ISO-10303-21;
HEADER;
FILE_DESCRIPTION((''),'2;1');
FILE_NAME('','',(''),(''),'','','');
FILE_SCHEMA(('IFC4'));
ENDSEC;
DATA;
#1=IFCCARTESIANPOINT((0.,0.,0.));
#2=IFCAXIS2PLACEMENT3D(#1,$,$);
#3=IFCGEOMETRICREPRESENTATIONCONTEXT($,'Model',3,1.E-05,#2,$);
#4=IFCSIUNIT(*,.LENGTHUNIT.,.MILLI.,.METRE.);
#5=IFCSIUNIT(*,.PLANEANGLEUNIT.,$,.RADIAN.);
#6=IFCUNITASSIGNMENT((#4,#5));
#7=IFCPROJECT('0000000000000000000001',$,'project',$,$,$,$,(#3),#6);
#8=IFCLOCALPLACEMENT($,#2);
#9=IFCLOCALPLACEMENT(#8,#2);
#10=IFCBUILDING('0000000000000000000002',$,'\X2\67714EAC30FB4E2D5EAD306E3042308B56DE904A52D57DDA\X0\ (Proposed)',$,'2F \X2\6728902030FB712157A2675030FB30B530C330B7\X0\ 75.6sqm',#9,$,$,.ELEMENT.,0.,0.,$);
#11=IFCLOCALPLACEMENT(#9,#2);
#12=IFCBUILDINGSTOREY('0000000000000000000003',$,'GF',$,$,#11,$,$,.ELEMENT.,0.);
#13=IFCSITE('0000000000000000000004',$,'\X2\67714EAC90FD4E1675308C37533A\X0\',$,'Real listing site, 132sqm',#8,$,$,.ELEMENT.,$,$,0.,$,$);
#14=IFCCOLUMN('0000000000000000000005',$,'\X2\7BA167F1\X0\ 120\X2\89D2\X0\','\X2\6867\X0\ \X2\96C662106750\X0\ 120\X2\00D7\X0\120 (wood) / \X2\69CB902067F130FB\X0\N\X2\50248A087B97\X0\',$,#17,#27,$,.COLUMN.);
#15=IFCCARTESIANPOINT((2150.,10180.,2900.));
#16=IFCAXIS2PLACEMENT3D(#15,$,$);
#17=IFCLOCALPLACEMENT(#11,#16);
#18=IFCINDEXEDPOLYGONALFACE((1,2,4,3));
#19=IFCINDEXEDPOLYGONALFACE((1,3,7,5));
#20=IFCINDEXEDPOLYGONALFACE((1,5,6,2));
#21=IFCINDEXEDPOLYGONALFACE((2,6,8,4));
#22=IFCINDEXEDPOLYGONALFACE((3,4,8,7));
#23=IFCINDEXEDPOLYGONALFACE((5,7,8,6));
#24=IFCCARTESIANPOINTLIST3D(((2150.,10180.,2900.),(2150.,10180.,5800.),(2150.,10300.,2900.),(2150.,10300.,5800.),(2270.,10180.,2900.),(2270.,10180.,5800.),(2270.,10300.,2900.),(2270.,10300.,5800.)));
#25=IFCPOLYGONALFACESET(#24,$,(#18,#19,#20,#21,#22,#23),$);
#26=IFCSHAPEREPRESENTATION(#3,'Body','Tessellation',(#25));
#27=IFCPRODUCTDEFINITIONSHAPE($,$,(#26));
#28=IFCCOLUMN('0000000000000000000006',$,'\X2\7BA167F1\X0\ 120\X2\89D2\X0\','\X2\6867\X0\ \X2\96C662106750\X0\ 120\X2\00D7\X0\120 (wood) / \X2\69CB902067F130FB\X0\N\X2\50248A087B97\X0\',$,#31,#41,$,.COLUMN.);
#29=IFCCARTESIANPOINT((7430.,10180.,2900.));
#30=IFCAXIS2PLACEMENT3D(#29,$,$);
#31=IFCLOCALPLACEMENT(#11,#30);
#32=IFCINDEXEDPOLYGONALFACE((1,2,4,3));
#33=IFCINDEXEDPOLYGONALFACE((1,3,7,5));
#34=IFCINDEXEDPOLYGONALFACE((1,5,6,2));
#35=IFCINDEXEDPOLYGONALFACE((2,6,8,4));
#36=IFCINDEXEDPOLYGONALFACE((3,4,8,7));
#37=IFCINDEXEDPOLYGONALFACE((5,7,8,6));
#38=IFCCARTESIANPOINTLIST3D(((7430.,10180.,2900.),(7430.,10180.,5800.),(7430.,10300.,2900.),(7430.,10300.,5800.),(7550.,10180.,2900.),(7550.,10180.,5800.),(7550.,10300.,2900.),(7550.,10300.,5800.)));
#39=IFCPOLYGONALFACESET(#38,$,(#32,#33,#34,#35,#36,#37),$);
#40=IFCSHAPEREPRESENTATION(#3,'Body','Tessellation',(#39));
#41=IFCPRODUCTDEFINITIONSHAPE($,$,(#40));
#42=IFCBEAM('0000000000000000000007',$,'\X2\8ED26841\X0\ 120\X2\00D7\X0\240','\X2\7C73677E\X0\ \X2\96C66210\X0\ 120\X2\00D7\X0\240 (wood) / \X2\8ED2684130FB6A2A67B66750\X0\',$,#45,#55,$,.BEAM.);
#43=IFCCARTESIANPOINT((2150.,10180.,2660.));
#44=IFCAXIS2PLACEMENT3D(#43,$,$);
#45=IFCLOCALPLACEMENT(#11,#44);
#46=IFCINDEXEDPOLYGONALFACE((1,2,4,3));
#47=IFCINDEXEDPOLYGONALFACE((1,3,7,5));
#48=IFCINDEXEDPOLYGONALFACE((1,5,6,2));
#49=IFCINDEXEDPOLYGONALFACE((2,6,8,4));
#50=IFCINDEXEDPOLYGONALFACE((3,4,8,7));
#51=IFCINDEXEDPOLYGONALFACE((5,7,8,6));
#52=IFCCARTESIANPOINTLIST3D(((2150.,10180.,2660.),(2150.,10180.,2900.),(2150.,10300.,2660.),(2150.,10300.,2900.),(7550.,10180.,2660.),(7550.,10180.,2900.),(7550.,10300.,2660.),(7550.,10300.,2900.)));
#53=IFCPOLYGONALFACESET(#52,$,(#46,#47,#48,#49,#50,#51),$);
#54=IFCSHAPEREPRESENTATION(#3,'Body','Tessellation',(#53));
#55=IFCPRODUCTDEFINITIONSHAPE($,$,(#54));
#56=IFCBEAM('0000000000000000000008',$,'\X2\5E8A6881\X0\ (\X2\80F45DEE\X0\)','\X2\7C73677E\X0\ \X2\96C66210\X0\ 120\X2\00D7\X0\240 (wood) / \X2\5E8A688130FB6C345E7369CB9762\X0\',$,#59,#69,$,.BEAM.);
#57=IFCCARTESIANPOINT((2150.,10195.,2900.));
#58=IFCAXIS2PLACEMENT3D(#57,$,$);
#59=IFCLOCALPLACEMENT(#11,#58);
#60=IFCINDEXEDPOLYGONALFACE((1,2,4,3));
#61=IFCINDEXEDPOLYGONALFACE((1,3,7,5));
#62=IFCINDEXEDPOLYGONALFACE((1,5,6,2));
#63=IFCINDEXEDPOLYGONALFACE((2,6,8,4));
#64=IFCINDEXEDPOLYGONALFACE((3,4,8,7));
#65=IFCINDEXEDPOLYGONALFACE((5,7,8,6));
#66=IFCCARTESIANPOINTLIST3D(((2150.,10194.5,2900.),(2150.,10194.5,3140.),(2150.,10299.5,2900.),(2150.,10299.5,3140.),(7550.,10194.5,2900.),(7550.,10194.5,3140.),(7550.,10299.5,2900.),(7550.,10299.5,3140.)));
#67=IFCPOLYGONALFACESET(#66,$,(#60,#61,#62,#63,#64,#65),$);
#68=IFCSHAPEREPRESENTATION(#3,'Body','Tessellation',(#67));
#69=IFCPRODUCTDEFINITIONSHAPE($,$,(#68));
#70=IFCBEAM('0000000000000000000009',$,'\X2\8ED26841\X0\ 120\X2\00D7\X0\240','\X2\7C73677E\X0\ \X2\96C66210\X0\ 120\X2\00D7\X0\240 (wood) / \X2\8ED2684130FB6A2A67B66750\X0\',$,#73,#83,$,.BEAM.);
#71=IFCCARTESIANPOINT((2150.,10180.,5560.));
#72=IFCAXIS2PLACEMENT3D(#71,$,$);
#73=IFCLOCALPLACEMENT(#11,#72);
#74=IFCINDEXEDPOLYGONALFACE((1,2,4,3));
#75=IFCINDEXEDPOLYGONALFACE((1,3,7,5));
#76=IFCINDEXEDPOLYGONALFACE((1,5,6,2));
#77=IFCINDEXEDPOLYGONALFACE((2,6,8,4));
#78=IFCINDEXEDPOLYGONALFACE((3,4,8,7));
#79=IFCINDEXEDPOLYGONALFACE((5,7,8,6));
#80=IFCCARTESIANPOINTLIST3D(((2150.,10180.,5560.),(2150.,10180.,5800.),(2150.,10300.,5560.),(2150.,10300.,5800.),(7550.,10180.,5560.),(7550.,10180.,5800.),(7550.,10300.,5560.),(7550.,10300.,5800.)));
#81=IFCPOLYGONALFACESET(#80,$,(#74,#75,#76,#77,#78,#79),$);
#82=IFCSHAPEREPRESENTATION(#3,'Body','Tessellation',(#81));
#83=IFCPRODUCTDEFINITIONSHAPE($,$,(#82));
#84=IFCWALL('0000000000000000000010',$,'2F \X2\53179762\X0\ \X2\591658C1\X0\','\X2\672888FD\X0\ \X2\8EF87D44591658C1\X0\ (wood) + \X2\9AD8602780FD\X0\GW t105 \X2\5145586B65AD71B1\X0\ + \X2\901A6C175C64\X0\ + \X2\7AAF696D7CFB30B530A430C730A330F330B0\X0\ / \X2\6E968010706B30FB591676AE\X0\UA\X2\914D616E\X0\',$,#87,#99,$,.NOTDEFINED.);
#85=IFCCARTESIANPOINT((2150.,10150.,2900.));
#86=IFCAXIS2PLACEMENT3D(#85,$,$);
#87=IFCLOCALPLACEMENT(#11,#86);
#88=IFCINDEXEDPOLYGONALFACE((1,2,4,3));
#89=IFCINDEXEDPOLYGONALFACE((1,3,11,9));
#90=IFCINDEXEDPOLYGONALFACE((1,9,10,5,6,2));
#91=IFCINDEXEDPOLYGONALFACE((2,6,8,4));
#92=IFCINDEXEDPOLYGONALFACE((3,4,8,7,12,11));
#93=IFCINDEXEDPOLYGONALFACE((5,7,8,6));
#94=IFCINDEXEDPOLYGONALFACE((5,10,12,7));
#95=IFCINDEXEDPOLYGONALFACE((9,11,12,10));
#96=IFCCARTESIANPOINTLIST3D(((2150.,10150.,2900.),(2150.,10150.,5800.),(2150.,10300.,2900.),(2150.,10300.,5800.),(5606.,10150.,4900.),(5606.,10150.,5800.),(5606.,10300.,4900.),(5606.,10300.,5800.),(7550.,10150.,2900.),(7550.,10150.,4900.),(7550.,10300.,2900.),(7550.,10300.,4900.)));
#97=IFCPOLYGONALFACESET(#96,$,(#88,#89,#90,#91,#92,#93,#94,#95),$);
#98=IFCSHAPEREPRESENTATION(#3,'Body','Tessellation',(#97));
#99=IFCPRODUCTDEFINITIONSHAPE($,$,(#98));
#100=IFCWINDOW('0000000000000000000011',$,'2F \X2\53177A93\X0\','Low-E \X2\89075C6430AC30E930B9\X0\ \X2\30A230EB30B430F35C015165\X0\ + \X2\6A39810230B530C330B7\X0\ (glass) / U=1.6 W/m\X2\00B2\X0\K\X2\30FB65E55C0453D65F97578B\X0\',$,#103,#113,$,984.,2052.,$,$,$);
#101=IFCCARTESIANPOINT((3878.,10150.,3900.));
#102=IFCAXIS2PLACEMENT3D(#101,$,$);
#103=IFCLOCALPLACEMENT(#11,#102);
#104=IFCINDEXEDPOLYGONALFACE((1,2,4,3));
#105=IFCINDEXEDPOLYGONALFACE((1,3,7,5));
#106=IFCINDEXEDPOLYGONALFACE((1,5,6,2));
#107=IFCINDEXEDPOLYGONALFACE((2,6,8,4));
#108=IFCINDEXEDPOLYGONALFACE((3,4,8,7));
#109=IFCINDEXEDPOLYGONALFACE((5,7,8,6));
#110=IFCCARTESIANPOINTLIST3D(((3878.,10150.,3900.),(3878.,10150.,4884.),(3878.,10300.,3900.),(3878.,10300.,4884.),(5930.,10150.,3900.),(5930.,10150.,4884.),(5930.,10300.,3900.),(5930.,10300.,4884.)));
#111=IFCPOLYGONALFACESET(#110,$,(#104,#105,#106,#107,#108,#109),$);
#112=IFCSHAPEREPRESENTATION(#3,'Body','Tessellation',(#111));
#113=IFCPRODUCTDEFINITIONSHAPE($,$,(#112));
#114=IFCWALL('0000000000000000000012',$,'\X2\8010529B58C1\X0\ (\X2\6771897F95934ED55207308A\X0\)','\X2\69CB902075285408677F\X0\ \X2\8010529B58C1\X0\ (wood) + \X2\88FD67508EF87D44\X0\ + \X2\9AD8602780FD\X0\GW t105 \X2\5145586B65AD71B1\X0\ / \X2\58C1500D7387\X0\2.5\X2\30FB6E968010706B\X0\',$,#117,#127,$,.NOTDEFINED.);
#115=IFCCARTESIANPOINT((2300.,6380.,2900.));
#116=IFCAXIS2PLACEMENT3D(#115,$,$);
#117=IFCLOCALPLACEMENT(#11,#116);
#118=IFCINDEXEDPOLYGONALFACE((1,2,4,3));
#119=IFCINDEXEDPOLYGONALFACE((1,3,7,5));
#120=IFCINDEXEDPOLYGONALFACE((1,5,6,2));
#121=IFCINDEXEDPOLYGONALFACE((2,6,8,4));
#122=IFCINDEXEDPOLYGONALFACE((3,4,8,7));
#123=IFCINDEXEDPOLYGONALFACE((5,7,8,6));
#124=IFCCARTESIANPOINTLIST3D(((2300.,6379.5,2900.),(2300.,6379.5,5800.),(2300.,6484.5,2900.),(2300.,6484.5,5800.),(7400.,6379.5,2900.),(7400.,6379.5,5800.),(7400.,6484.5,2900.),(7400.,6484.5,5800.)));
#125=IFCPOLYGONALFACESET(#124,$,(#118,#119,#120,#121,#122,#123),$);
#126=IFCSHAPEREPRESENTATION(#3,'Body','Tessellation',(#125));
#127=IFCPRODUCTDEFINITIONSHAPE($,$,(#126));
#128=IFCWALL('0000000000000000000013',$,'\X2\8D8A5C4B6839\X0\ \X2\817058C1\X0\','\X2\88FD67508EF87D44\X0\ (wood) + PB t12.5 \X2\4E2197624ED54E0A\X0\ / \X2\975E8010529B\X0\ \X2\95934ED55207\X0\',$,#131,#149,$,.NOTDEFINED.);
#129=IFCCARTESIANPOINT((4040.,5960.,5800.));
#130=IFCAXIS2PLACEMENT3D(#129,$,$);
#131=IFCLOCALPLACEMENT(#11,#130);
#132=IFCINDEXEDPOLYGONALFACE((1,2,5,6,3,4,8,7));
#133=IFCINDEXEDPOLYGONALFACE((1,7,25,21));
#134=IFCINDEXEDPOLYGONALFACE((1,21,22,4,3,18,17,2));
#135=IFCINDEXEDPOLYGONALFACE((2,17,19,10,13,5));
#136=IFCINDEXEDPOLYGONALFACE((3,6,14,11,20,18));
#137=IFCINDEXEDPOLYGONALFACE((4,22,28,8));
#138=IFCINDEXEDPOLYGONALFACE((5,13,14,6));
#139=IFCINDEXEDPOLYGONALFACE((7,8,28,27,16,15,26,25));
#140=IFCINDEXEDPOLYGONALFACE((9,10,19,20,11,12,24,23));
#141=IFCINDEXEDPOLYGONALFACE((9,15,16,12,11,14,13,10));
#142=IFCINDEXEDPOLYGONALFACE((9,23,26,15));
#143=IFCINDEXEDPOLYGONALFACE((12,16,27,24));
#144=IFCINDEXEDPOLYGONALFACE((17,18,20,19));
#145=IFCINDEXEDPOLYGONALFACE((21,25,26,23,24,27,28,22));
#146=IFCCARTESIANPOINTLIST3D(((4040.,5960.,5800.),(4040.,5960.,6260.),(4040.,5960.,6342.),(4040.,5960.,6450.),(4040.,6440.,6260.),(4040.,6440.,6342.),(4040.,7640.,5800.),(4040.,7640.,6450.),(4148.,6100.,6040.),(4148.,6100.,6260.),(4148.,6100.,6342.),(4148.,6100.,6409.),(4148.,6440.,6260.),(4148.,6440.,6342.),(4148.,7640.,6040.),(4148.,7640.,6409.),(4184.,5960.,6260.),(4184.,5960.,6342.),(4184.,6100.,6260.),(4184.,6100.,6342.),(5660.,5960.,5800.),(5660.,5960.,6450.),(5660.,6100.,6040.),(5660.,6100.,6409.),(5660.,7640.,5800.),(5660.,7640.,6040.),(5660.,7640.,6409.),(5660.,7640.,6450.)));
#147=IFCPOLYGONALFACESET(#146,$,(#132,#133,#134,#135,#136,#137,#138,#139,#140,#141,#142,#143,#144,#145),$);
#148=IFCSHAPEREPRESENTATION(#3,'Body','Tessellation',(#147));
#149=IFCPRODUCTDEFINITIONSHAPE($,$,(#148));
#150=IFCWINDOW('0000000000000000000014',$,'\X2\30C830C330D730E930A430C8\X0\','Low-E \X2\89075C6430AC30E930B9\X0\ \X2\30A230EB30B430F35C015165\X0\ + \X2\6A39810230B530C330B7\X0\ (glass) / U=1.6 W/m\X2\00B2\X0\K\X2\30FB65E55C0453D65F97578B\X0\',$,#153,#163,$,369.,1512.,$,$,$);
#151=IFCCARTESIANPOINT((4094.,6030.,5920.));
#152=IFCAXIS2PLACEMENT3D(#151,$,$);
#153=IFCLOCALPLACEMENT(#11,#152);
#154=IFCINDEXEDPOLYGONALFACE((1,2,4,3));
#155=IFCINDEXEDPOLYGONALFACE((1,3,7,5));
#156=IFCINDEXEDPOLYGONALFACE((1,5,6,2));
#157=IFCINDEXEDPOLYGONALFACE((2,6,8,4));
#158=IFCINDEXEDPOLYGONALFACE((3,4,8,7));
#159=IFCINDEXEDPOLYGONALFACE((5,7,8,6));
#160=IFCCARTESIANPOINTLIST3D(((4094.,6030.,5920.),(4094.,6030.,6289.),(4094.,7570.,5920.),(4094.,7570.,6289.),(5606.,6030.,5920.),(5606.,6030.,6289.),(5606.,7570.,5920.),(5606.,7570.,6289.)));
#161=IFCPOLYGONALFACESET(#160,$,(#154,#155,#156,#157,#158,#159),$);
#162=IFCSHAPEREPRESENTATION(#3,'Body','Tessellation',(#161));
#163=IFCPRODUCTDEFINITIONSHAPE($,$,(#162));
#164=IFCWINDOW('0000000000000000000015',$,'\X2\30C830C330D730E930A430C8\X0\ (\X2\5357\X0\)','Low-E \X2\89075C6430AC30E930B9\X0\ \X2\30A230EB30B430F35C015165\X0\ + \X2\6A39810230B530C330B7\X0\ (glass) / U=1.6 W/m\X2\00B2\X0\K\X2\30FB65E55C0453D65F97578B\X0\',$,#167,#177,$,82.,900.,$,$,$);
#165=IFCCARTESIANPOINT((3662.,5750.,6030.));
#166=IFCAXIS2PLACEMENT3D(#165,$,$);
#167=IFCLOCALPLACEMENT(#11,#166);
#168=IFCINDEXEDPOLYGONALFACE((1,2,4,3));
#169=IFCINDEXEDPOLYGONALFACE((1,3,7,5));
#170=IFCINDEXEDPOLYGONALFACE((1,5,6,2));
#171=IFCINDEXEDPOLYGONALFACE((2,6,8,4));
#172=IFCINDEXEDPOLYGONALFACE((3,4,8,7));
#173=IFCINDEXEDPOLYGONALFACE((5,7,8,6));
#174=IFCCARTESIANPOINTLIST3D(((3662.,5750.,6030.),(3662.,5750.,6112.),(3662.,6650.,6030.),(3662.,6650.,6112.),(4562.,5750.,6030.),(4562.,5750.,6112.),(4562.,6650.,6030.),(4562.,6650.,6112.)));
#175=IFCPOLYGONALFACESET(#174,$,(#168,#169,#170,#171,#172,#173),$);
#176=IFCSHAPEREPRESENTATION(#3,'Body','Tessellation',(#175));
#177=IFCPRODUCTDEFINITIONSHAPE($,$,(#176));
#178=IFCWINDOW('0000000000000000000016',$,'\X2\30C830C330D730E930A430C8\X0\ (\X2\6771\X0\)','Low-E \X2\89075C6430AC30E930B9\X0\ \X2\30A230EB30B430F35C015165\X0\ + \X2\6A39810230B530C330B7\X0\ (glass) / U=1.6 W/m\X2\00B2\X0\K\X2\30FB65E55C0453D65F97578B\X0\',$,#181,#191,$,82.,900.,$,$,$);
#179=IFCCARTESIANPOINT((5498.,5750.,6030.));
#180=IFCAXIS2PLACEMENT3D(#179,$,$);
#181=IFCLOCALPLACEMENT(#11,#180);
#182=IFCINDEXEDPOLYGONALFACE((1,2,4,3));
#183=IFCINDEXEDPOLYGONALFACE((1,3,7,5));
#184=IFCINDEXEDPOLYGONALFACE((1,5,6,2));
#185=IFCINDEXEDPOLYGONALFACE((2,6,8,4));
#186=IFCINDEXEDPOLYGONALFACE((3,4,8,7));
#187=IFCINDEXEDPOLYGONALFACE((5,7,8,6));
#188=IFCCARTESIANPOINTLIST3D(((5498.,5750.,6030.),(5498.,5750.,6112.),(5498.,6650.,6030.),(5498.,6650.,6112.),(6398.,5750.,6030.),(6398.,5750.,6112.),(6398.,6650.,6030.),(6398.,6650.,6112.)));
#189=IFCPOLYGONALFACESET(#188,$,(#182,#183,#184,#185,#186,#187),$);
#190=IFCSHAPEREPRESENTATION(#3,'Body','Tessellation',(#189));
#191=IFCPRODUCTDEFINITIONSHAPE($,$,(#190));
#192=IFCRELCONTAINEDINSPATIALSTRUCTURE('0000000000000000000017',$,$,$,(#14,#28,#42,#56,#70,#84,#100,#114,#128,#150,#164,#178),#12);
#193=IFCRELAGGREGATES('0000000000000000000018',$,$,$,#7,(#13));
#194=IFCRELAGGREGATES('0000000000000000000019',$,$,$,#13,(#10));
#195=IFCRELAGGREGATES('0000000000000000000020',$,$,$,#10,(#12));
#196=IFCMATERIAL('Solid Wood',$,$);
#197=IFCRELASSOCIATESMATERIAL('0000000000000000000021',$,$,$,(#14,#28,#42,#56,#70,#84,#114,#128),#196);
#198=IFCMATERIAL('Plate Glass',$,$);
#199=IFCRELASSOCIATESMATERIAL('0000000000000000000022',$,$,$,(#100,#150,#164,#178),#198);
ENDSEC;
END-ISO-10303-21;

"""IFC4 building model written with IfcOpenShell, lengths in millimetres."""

from ifc_helpers import new_model, si_unit, frame, frame_2d, origin, place, context, project, spatial, rectangle, extrude, material, element, fill, save


model = new_model("IFC4")

# Units and contexts
model_context = context("Model", 3, precision=1e-05, world=origin())
ifc_project = project(units=[si_unit("LENGTHUNIT", "METRE", prefix="MILLI"), si_unit("PLANEANGLEUNIT", "RADIAN")], contexts=[model_context])

# Site, building, storey
site_placement = place(None, origin())
site = spatial("IfcSite", under=ifc_project, at=site_placement, Name="東京都世田谷区", ObjectType="Real listing site, 132sqm", CompositionType="ELEMENT", RefElevation=0.0)
building_placement = place(site_placement, origin())
building = spatial("IfcBuilding", under=site, at=building_placement, Name="東京・中庭のある回遊動線 (Proposed)", ObjectType="2F 木造・無垢材・サッシ 75.6sqm", CompositionType="ELEMENT", ElevationOfRefHeight=0.0, ElevationOfTerrain=0.0)
storey_placement = place(building_placement, origin())
storey = spatial("IfcBuildingStorey", under=building, at=storey_placement, Name="GF", CompositionType="ELEMENT", Elevation=0.0)

# Columns
ifc_material_1 = material(Name="Solid Wood")
column_1_placement = place(storey_placement, frame((2150.0, 10180.0, 2900.0)))
element("IfcColumn", 1, at=column_1_placement, inside=storey, material=ifc_material_1, Name="管柱 120角", Description="桧 集成材 120×120 (wood) / 構造柱・N値計算", PredefinedType="COLUMN", context=model_context, shape_type="SweptSolid", body=[
    extrude(rectangle(XDim=120.0, YDim=120.0, at=frame_2d((60.0, 60.0))), frame((2150.0, 10180.0, 2900.0)), (0.0, 0.0, 1.0), 2900.0),
])
column_2_placement = place(storey_placement, frame((7430.0, 10180.0, 2900.0)))
element("IfcColumn", 2, at=column_2_placement, inside=storey, material=ifc_material_1, Name="管柱 120角", Description="桧 集成材 120×120 (wood) / 構造柱・N値計算", PredefinedType="COLUMN", context=model_context, shape_type="SweptSolid", body=[
    extrude(rectangle(XDim=120.0, YDim=120.0, at=frame_2d((60.0, 60.0))), frame((7430.0, 10180.0, 2900.0)), (0.0, 0.0, 1.0), 2900.0),
])

# Beams
beam_1_placement = place(storey_placement, frame((2150.0, 10180.0, 2660.0)))
element("IfcBeam", 3, at=beam_1_placement, inside=storey, material=ifc_material_1, Name="軒桁 120×240", Description="米松 集成 120×240 (wood) / 軒桁・横架材", PredefinedType="BEAM", context=model_context, shape_type="SweptSolid", body=[
    extrude(rectangle(XDim=5400.0, YDim=120.0, at=frame_2d((2700.0, 60.0))), frame((2150.0, 10180.0, 2660.0)), (0.0, 0.0, 1.0), 240.0),
])
beam_2_placement = place(storey_placement, frame((2150.0, 10195.0, 2900.0)))
element("IfcBeam", 4, at=beam_2_placement, inside=storey, material=ifc_material_1, Name="床梁 (胴差)", Description="米松 集成 120×240 (wood) / 床梁・水平構面", PredefinedType="BEAM", context=model_context, shape_type="SweptSolid", body=[
    extrude(rectangle(XDim=5400.0, YDim=105.0, at=frame_2d((2700.0, 52.0))), frame((2150.0, 10195.0, 2900.0)), (0.0, 0.0, 1.0), 240.0),
])
beam_3_placement = place(storey_placement, frame((2150.0, 10180.0, 5560.0)))
element("IfcBeam", 5, at=beam_3_placement, inside=storey, material=ifc_material_1, Name="軒桁 120×240", Description="米松 集成 120×240 (wood) / 軒桁・横架材", PredefinedType="BEAM", context=model_context, shape_type="SweptSolid", body=[
    extrude(rectangle(XDim=5400.0, YDim=120.0, at=frame_2d((2700.0, 60.0))), frame((2150.0, 10180.0, 5560.0)), (0.0, 0.0, 1.0), 240.0),
])

# Wall, opening, window
wall_1_placement = place(storey_placement, frame((2150.0, 10150.0, 2900.0)))
wall_1 = element("IfcWall", 6, at=wall_1_placement, inside=storey, material=ifc_material_1, Name="2F 北面 外壁", Description="木製 軸組外壁 (wood) + 高性能GW t105 充填断熱 + 通気層 + 窯業系サイディング / 準耐火・外皮UA配慮", PredefinedType="NOTDEFINED", context=model_context, shape_type="SweptSolid", body=[
    extrude(rectangle(XDim=5400.0, YDim=150.0, at=frame_2d((2700.0, 75.0))), frame((2150.0, 10150.0, 2900.0)), (0.0, 0.0, 1.0), 2900.0),
])
opening_1_placement = place(storey_placement, frame((3878.0, 10150.0, 3900.0)))
opening_1 = element("IfcOpeningElement", 7, at=opening_1_placement, cuts=wall_1, PredefinedType="NOTDEFINED", context=model_context, shape_type="SweptSolid", body=[
    extrude(rectangle(XDim=2052.0, YDim=150.0, at=frame_2d((1026.0, 75.0))), frame((3878.0, 10150.0, 3900.0)), (0.0, 0.0, 1.0), 984.0),
])
ifc_material_2 = material(Name="Plate Glass")
window_1_placement = place(storey_placement, frame((3878.0, 10150.0, 3900.0)))
window_1 = element("IfcWindow", 8, at=window_1_placement, inside=storey, material=ifc_material_2, Name="2F 北窓", Description="Low-E 複層ガラス アルゴン封入 + 樹脂サッシ (glass) / U=1.6 W/m²K・日射取得型", OverallHeight=984.0, OverallWidth=2052.0, context=model_context, shape_type="SweptSolid", body=[
    extrude(rectangle(XDim=2052.0, YDim=150.0, at=frame_2d((1026.0, 75.0))), frame((3878.0, 10150.0, 3900.0)), (0.0, 0.0, 1.0), 984.0),
])
fill(opening_1, window_1)

# Wall
wall_2_placement = place(storey_placement, frame((2300.0, 6380.0, 2900.0)))
element("IfcWall", 9, at=wall_2_placement, inside=storey, material=ifc_material_1, Name="耐力壁 (東西間仕切り)", Description="構造用合板 耐力壁 (wood) + 製材軸組 + 高性能GW t105 充填断熱 / 壁倍率2.5・準耐火", PredefinedType="NOTDEFINED", context=model_context, shape_type="SweptSolid", body=[
    extrude(rectangle(XDim=5100.0, YDim=105.0, at=frame_2d((2550.0, 52.0))), frame((2300.0, 6380.0, 2900.0)), (0.0, 0.0, 1.0), 2900.0),
])

# Wall, openings, windows
wall_3_placement = place(storey_placement, frame((4040.0, 5960.0, 5800.0)))
wall_3 = element("IfcWall", 10, at=wall_3_placement, inside=storey, material=ifc_material_1, Name="越屋根 腰壁", Description="製材軸組 (wood) + PB t12.5 両面仕上 / 非耐力 間仕切", PredefinedType="NOTDEFINED", context=model_context, shape_type="SweptSolid", body=[
    extrude(rectangle(XDim=1620.0, YDim=1680.0, at=frame_2d((810.0, 840.0))), frame((4040.0, 5960.0, 5800.0)), (0.0, 0.0, 1.0), 650.0),
])
opening_2_placement = place(storey_placement, frame((4094.0, 6030.0, 5920.0)))
opening_2 = element("IfcOpeningElement", 11, at=opening_2_placement, cuts=wall_3, PredefinedType="NOTDEFINED", context=model_context, shape_type="SweptSolid", body=[
    extrude(rectangle(XDim=1512.0, YDim=1540.0, at=frame_2d((756.0, 770.0))), frame((4094.0, 6030.0, 5920.0)), (0.0, 0.0, 1.0), 369.0),
])
opening_3_placement = place(storey_placement, frame((3662.0, 5750.0, 6030.0)))
opening_3 = element("IfcOpeningElement", 12, at=opening_3_placement, cuts=wall_3, PredefinedType="NOTDEFINED", context=model_context, shape_type="SweptSolid", body=[
    extrude(rectangle(XDim=900.0, YDim=900.0, at=frame_2d((450.0, 450.0))), frame((3662.0, 5750.0, 6030.0)), (0.0, 0.0, 1.0), 82.0),
])
opening_4_placement = place(storey_placement, frame((5498.0, 5750.0, 6030.0)))
opening_4 = element("IfcOpeningElement", 13, at=opening_4_placement, cuts=wall_3, PredefinedType="NOTDEFINED", context=model_context, shape_type="SweptSolid", body=[
    extrude(rectangle(XDim=900.0, YDim=900.0, at=frame_2d((450.0, 450.0))), frame((5498.0, 5750.0, 6030.0)), (0.0, 0.0, 1.0), 82.0),
])
window_2_placement = place(storey_placement, frame((4094.0, 6030.0, 5920.0)))
window_2 = element("IfcWindow", 14, at=window_2_placement, inside=storey, material=ifc_material_2, Name="トップライト", Description="Low-E 複層ガラス アルゴン封入 + 樹脂サッシ (glass) / U=1.6 W/m²K・日射取得型", OverallHeight=369.0, OverallWidth=1512.0, context=model_context, shape_type="SweptSolid", body=[
    extrude(rectangle(XDim=1512.0, YDim=1540.0, at=frame_2d((756.0, 770.0))), frame((4094.0, 6030.0, 5920.0)), (0.0, 0.0, 1.0), 369.0),
])
fill(opening_2, window_2)
window_3_placement = place(storey_placement, frame((3662.0, 5750.0, 6030.0)))
window_3 = element("IfcWindow", 15, at=window_3_placement, inside=storey, material=ifc_material_2, Name="トップライト (南)", Description="Low-E 複層ガラス アルゴン封入 + 樹脂サッシ (glass) / U=1.6 W/m²K・日射取得型", OverallHeight=82.0, OverallWidth=900.0, context=model_context, shape_type="SweptSolid", body=[
    extrude(rectangle(XDim=900.0, YDim=900.0, at=frame_2d((450.0, 450.0))), frame((3662.0, 5750.0, 6030.0)), (0.0, 0.0, 1.0), 82.0),
])
fill(opening_3, window_3)
window_4_placement = place(storey_placement, frame((5498.0, 5750.0, 6030.0)))
window_4 = element("IfcWindow", 16, at=window_4_placement, inside=storey, material=ifc_material_2, Name="トップライト (東)", Description="Low-E 複層ガラス アルゴン封入 + 樹脂サッシ (glass) / U=1.6 W/m²K・日射取得型", OverallHeight=82.0, OverallWidth=900.0, context=model_context, shape_type="SweptSolid", body=[
    extrude(rectangle(XDim=900.0, YDim=900.0, at=frame_2d((450.0, 450.0))), frame((5498.0, 5750.0, 6030.0)), (0.0, 0.0, 1.0), 82.0),
])
fill(opening_4, window_4)

save(model, "model.ifc")
